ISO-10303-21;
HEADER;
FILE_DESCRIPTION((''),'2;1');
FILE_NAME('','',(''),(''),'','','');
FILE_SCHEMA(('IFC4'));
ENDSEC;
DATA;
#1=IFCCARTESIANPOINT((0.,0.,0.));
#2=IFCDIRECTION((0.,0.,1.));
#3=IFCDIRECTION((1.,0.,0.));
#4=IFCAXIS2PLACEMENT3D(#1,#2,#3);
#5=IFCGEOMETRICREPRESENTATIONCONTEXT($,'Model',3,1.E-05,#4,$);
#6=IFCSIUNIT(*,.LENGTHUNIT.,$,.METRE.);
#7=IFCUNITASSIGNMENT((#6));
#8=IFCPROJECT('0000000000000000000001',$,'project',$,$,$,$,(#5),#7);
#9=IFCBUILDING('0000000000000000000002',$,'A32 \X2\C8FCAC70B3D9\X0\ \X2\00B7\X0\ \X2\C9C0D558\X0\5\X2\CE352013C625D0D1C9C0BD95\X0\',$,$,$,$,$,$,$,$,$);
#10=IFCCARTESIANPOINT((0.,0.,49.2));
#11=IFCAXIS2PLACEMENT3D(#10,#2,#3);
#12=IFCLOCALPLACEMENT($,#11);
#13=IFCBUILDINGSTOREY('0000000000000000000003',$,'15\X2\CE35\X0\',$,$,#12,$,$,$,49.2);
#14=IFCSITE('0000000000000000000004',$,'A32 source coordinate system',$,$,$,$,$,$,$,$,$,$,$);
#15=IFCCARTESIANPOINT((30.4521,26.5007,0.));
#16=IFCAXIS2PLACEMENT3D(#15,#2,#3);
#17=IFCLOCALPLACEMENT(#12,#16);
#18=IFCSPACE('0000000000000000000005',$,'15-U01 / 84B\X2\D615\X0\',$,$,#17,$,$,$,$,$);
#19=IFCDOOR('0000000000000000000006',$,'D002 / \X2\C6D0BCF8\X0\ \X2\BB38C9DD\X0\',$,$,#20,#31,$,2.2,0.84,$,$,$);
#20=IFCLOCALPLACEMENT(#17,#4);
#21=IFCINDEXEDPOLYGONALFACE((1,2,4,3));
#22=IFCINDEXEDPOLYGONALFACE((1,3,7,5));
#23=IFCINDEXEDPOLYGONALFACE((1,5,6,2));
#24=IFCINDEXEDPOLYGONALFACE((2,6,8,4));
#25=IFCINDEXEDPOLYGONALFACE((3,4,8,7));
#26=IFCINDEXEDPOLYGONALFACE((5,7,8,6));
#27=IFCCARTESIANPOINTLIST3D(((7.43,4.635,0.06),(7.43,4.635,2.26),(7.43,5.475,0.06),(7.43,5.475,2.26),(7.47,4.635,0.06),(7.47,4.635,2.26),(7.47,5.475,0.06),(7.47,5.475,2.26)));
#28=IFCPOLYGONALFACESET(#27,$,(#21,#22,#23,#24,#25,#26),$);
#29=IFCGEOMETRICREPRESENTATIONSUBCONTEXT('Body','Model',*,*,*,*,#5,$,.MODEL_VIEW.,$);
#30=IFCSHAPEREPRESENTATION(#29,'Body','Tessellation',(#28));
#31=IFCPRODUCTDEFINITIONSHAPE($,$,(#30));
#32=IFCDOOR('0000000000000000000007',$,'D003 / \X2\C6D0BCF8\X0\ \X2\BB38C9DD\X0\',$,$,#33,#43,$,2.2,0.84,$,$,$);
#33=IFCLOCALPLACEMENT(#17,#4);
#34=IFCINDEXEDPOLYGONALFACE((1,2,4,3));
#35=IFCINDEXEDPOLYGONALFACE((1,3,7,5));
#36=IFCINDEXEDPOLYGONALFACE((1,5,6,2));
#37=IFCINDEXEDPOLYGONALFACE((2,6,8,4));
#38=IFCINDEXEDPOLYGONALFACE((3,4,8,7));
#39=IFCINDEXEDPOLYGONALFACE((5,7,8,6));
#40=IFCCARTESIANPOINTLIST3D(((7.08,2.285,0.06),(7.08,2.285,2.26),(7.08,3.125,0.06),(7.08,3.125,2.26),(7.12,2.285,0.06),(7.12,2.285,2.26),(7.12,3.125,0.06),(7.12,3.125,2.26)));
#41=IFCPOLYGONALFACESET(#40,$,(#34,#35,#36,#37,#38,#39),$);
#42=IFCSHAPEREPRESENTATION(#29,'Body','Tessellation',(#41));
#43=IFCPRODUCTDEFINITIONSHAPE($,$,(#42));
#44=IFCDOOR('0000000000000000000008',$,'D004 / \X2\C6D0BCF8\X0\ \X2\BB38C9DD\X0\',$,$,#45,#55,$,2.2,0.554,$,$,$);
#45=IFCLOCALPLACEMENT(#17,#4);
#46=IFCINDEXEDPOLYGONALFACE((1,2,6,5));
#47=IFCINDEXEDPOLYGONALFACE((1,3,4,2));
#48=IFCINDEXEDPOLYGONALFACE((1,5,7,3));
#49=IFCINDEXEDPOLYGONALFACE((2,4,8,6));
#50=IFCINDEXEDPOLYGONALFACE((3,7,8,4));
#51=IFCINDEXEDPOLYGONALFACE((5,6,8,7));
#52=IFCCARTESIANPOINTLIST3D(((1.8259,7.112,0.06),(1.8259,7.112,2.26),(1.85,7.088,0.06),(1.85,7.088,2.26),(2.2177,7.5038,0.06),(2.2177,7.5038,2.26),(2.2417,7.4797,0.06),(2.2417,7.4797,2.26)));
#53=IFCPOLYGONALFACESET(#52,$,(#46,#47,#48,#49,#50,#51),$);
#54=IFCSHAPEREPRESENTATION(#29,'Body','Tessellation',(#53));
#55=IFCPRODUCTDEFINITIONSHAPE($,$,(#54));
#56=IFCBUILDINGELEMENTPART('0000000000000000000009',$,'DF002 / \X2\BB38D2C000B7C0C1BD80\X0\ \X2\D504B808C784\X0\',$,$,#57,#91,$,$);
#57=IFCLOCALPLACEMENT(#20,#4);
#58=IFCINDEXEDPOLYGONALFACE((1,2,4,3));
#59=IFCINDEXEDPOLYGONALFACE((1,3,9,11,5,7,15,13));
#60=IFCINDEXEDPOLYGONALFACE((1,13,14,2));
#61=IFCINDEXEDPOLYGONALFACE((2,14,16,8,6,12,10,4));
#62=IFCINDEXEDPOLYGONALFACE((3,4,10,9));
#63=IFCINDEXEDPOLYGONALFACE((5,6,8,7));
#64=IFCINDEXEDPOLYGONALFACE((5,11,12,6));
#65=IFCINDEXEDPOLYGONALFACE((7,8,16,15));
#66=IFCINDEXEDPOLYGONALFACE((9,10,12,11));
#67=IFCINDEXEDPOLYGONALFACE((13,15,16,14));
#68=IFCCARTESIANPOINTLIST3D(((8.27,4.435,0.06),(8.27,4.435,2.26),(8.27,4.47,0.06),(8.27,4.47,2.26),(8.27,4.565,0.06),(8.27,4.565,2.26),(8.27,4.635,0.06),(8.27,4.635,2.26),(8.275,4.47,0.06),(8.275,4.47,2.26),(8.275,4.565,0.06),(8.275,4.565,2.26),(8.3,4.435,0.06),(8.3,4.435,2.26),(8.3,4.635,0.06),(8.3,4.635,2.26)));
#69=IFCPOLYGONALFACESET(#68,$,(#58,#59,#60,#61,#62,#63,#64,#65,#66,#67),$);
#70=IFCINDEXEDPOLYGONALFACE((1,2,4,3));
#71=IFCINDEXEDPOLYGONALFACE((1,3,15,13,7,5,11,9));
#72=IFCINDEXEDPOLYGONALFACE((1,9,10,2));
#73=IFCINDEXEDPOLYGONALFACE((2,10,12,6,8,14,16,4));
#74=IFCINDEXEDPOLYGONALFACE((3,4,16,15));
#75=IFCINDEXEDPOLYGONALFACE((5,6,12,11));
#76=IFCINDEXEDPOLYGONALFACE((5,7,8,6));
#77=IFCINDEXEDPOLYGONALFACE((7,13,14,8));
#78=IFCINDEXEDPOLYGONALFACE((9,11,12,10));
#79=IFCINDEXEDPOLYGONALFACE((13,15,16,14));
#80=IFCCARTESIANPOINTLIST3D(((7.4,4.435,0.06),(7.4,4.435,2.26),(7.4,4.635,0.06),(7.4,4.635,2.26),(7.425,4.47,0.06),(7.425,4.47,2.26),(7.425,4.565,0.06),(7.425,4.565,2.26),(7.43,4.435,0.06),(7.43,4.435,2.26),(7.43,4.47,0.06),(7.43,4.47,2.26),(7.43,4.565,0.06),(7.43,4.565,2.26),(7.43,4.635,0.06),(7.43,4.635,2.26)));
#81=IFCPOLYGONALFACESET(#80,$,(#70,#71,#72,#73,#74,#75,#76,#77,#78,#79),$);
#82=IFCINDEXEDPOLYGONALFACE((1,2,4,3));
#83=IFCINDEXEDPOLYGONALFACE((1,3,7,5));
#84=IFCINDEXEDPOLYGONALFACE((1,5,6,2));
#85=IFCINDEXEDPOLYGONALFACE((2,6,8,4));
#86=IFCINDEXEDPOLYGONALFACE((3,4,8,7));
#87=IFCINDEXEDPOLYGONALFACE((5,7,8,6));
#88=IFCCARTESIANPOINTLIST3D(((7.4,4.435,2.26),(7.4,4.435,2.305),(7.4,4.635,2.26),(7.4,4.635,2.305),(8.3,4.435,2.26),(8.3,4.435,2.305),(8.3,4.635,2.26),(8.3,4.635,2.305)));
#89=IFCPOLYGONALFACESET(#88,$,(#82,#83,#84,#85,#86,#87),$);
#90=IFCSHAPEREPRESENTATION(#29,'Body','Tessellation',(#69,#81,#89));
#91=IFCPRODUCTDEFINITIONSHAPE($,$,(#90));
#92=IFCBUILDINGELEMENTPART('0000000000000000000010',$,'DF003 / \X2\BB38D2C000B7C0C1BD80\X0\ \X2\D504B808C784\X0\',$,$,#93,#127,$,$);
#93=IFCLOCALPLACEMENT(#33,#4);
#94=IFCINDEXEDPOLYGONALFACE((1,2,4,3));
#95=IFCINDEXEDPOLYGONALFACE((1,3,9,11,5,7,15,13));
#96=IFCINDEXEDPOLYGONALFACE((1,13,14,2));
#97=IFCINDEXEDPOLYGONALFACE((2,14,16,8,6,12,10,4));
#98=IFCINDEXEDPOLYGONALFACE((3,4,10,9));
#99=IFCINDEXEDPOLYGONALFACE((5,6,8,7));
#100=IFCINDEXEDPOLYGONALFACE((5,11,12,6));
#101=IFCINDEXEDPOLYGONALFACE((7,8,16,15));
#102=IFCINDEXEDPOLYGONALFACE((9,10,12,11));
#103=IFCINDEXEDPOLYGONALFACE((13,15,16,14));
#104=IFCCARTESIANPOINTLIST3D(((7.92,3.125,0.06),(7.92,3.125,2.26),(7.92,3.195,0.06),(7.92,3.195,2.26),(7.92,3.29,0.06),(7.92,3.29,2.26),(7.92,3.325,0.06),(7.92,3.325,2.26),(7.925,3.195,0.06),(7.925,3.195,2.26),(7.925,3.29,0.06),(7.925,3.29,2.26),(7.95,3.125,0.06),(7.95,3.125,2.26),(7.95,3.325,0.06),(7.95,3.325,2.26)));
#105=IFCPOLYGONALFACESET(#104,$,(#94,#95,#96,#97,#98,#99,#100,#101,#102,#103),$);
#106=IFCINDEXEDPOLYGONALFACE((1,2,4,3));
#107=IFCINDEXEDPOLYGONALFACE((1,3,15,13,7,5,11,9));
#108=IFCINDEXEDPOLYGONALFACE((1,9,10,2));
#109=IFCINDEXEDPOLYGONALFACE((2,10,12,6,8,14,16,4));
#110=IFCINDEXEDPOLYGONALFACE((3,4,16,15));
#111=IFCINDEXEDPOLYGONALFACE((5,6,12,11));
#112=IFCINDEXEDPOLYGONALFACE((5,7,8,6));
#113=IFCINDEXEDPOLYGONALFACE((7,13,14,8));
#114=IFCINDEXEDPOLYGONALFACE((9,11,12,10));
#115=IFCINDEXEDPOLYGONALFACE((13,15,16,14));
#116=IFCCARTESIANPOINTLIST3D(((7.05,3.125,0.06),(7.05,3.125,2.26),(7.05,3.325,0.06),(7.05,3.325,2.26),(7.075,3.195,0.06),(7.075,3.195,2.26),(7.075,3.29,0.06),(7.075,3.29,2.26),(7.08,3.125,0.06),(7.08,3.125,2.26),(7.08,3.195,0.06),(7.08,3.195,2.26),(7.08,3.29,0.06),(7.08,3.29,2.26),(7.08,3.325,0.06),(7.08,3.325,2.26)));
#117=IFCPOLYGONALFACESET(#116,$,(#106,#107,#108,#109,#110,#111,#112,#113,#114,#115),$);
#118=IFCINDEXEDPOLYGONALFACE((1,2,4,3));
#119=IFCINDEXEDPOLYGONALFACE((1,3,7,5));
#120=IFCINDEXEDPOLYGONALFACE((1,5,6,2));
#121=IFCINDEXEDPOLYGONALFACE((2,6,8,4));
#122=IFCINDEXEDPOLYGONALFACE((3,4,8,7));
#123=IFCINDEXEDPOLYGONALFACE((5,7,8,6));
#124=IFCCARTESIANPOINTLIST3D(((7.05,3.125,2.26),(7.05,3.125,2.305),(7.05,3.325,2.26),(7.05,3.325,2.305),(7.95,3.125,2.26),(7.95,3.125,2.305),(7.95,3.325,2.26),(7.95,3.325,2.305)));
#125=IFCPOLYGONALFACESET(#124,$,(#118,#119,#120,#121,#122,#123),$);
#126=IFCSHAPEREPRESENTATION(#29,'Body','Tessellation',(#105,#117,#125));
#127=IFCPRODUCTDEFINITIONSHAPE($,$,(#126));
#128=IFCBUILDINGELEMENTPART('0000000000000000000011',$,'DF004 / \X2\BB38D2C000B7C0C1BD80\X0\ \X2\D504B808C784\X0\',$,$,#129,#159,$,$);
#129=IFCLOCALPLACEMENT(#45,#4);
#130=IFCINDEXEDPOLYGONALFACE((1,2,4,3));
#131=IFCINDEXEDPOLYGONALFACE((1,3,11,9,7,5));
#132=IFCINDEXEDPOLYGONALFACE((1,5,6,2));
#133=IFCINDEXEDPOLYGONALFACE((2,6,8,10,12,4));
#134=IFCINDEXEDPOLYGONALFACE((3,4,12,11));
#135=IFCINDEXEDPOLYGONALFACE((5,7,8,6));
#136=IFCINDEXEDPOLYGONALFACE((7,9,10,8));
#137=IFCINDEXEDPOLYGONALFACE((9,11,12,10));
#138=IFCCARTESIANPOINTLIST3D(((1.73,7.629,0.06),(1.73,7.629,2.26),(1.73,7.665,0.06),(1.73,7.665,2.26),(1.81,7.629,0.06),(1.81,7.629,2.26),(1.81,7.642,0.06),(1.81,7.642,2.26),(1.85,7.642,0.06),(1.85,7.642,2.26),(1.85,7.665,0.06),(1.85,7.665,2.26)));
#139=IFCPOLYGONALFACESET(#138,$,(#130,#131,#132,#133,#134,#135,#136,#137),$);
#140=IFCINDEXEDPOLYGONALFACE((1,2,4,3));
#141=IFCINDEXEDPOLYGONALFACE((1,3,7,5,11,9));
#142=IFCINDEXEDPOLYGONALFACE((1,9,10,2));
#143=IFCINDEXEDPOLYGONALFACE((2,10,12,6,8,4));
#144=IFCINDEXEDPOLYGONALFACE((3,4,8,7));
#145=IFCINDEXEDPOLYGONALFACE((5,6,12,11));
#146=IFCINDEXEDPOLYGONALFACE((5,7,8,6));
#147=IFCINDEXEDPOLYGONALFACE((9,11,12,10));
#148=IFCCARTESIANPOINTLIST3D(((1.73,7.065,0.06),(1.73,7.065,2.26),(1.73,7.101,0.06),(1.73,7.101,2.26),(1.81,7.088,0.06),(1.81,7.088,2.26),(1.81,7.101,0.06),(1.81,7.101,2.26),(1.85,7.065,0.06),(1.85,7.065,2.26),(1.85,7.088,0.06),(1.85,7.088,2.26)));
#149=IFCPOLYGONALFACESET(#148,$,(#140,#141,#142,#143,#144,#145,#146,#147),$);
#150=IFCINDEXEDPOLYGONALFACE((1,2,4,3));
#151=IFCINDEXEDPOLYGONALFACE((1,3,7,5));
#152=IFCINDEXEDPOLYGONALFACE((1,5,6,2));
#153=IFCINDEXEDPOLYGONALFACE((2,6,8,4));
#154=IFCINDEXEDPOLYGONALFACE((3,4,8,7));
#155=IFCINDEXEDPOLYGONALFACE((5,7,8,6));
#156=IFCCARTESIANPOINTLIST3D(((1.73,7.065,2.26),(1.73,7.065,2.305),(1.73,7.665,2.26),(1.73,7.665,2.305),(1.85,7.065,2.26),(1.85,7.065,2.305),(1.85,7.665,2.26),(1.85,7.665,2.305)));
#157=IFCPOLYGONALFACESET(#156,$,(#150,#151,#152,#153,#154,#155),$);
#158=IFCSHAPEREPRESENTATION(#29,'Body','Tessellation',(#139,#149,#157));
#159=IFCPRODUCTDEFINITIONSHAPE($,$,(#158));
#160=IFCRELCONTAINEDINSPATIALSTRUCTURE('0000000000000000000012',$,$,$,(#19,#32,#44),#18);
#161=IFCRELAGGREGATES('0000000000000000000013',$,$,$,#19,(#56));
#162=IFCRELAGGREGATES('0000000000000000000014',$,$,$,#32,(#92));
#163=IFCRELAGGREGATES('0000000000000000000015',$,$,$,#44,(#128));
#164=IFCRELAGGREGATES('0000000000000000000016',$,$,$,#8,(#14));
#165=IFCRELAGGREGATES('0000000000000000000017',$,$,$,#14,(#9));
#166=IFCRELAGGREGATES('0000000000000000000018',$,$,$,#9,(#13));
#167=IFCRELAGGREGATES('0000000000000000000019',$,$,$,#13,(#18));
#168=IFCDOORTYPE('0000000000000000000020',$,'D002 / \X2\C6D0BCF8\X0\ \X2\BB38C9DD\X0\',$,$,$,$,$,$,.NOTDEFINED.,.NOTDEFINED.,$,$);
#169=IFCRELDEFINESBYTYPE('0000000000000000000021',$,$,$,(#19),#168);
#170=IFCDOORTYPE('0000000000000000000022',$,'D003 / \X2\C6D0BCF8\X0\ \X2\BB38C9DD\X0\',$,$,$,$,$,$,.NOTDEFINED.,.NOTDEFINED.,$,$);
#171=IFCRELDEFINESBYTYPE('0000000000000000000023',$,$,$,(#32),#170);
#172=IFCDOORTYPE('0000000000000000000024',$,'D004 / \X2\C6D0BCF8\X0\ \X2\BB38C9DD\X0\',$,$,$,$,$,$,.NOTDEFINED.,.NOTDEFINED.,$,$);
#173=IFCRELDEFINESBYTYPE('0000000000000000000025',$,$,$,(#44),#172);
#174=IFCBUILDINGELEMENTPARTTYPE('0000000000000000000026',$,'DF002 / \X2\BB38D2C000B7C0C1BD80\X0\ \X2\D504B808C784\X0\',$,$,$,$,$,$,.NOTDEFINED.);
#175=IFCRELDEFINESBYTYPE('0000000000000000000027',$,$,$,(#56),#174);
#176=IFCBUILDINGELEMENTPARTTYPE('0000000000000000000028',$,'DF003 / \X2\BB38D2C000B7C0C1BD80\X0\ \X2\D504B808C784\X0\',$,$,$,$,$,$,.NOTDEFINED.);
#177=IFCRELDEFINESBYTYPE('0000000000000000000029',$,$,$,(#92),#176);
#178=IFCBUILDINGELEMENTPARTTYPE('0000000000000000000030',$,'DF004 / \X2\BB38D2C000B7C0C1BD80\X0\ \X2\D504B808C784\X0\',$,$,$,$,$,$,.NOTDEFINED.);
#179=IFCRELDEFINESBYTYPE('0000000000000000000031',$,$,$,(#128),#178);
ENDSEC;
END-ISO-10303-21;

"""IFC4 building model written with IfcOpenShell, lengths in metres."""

from ifc_helpers import new_model, si_unit, frame, origin, origin_with_axes, place, context, subcontext, project, spatial, polyline, outline, extrude, source, transform, mapped, type_object, type_shapes, element, aggregate, save


model = new_model("IFC4")

# Units and contexts
model_context = context("Model", 3, precision=1e-05, world=origin_with_axes())
body_context = subcontext(model_context, "Body", "Model", "MODEL_VIEW")
ifc_project = project(units=[si_unit("LENGTHUNIT", "METRE")], contexts=[model_context])

# Site, building, storey, space
storey_placement = place(None, frame((0.0, 0.0, 49.2), z_axis=(0.0, 0.0, 1.0), x_axis=(1.0, 0.0, 0.0)))
space_placement = place(storey_placement, frame((30.4521, 26.5007, 0.0), z_axis=(0.0, 0.0, 1.0), x_axis=(1.0, 0.0, 0.0)))
site = spatial("IfcSite", under=ifc_project, Name="A32 source coordinate system")
building = spatial("IfcBuilding", under=site, Name="A32 주거동 · 지하5층–옥탑지붕")
storey = spatial("IfcBuildingStorey", under=building, at=storey_placement, Name="15층", Elevation=49.2)
space = spatial("IfcSpace", under=storey, at=space_placement, Name="15-U01 / 84B형")

# Doors
door_type_1 = type_object("IfcDoorType", Name="D002 / 원본 문짝", OperationType="NOTDEFINED", PredefinedType="NOTDEFINED")
shared_shape_1 = source(origin(), body_context, "Body", "SweptSolid", [
    extrude(outline(polyline([(7.43, 4.635), (7.43, 5.475), (7.47, 5.475), (7.47, 4.635), (7.43, 4.635)])), frame((0.0, 0.0, 0.06)), (0.0, 0.0, 1.0), 2.2),
])
type_shapes(door_type_1, [shared_shape_1])
door_1_placement = place(space_placement, origin_with_axes())
door_1 = element("IfcDoor", 1, at=door_1_placement, inside=space, type_object=door_type_1, Name="D002 / 원본 문짝", OverallHeight=2.2, OverallWidth=0.84, context=body_context, shape_type="MappedRepresentation", body=[
    mapped(shared_shape_1, transform((0.0, 0.0, 0.0), scale=1.0)),
])
door_type_2 = type_object("IfcDoorType", Name="D003 / 원본 문짝", OperationType="NOTDEFINED", PredefinedType="NOTDEFINED")
shared_shape_2 = source(origin(), body_context, "Body", "SweptSolid", [
    extrude(outline(polyline([(7.12, 2.285), (7.08, 2.285), (7.08, 3.125), (7.12, 3.125), (7.12, 2.285)])), frame((0.0, 0.0, 0.06)), (0.0, 0.0, 1.0), 2.2),
])
type_shapes(door_type_2, [shared_shape_2])
door_2_placement = place(space_placement, origin_with_axes())
door_2 = element("IfcDoor", 2, at=door_2_placement, inside=space, type_object=door_type_2, Name="D003 / 원본 문짝", OverallHeight=2.2, OverallWidth=0.84, context=body_context, shape_type="MappedRepresentation", body=[
    mapped(shared_shape_2, transform((0.0, 0.0, 0.0), scale=1.0)),
])
door_type_3 = type_object("IfcDoorType", Name="D004 / 원본 문짝", OperationType="NOTDEFINED", PredefinedType="NOTDEFINED")
shared_shape_3 = source(origin(), body_context, "Body", "SweptSolid", [
    extrude(outline(polyline([(2.2177, 7.5038), (2.2417, 7.4797), (1.85, 7.088), (1.8259, 7.112), (2.2177, 7.5038)])), frame((0.0, 0.0, 0.06)), (0.0, 0.0, 1.0), 2.2),
])
type_shapes(door_type_3, [shared_shape_3])
door_3_placement = place(space_placement, origin_with_axes())
door_3 = element("IfcDoor", 3, at=door_3_placement, inside=space, type_object=door_type_3, Name="D004 / 원본 문짝", OverallHeight=2.2, OverallWidth=0.554, context=body_context, shape_type="MappedRepresentation", body=[
    mapped(shared_shape_3, transform((0.0, 0.0, 0.0), scale=1.0)),
])

# Building element parts
building_element_part_type_1 = type_object("IfcBuildingElementPartType", Name="DF002 / 문틀·상부 프레임", PredefinedType="NOTDEFINED")
shared_shape_4 = source(origin(), body_context, "Body", "SweptSolid", [
    extrude(outline(polyline([(8.3, 4.435), (8.27, 4.435), (8.27, 4.47), (8.275, 4.47), (8.275, 4.565), (8.27, 4.565), (8.27, 4.635), (8.3, 4.635), (8.3, 4.435)])), frame((0.0, 0.0, 0.06)), (0.0, 0.0, 1.0), 2.2),
    extrude(outline(polyline([(7.43, 4.635), (7.43, 4.565), (7.425, 4.565), (7.425, 4.47), (7.43, 4.47), (7.43, 4.435), (7.4, 4.435), (7.4, 4.635), (7.43, 4.635)])), frame((0.0, 0.0, 0.06)), (0.0, 0.0, 1.0), 2.2),
    extrude(outline(polyline([(7.4, 4.435), (7.4, 4.635), (8.3, 4.635), (8.3, 4.435), (7.4, 4.435)])), frame((0.0, 0.0, 2.26)), (0.0, 0.0, 1.0), 0.045),
])
type_shapes(building_element_part_type_1, [shared_shape_4])
building_element_part_1_placement = place(door_1_placement, origin_with_axes())
building_element_part_1 = element("IfcBuildingElementPart", 4, at=building_element_part_1_placement, type_object=building_element_part_type_1, Name="DF002 / 문틀·상부 프레임", context=body_context, shape_type="MappedRepresentation", body=[
    mapped(shared_shape_4, transform((0.0, 0.0, 0.0), scale=1.0)),
])
aggregate(door_1, [building_element_part_1])
building_element_part_type_2 = type_object("IfcBuildingElementPartType", Name="DF003 / 문틀·상부 프레임", PredefinedType="NOTDEFINED")
shared_shape_5 = source(origin(), body_context, "Body", "SweptSolid", [
    extrude(outline(polyline([(7.92, 3.125), (7.92, 3.195), (7.925, 3.195), (7.925, 3.29), (7.92, 3.29), (7.92, 3.325), (7.95, 3.325), (7.95, 3.125), (7.92, 3.125)])), frame((0.0, 0.0, 0.06)), (0.0, 0.0, 1.0), 2.2),
    extrude(outline(polyline([(7.05, 3.325), (7.08, 3.325), (7.08, 3.29), (7.075, 3.29), (7.075, 3.195), (7.08, 3.195), (7.08, 3.125), (7.05, 3.125), (7.05, 3.325)])), frame((0.0, 0.0, 0.06)), (0.0, 0.0, 1.0), 2.2),
    extrude(outline(polyline([(7.05, 3.125), (7.05, 3.325), (7.95, 3.325), (7.95, 3.125), (7.05, 3.125)])), frame((0.0, 0.0, 2.26)), (0.0, 0.0, 1.0), 0.045),
])
type_shapes(building_element_part_type_2, [shared_shape_5])
building_element_part_2_placement = place(door_2_placement, origin_with_axes())
building_element_part_2 = element("IfcBuildingElementPart", 5, at=building_element_part_2_placement, type_object=building_element_part_type_2, Name="DF003 / 문틀·상부 프레임", context=body_context, shape_type="MappedRepresentation", body=[
    mapped(shared_shape_5, transform((0.0, 0.0, 0.0), scale=1.0)),
])
aggregate(door_2, [building_element_part_2])
building_element_part_type_3 = type_object("IfcBuildingElementPartType", Name="DF004 / 문틀·상부 프레임", PredefinedType="NOTDEFINED")
shared_shape_6 = source(origin(), body_context, "Body", "SweptSolid", [
    extrude(outline(polyline([(1.85, 7.665), (1.85, 7.642), (1.81, 7.642), (1.81, 7.629), (1.73, 7.629), (1.73, 7.665), (1.85, 7.665)])), frame((0.0, 0.0, 0.06)), (0.0, 0.0, 1.0), 2.2),
    extrude(outline(polyline([(1.73, 7.101), (1.81, 7.101), (1.81, 7.088), (1.85, 7.088), (1.85, 7.065), (1.73, 7.065), (1.73, 7.101)])), frame((0.0, 0.0, 0.06)), (0.0, 0.0, 1.0), 2.2),
    extrude(outline(polyline([(1.73, 7.065), (1.73, 7.665), (1.85, 7.665), (1.85, 7.065), (1.73, 7.065)])), frame((0.0, 0.0, 2.26)), (0.0, 0.0, 1.0), 0.045),
])
type_shapes(building_element_part_type_3, [shared_shape_6])
building_element_part_3_placement = place(door_3_placement, origin_with_axes())
building_element_part_3 = element("IfcBuildingElementPart", 6, at=building_element_part_3_placement, type_object=building_element_part_type_3, Name="DF004 / 문틀·상부 프레임", context=body_context, shape_type="MappedRepresentation", body=[
    mapped(shared_shape_6, transform((0.0, 0.0, 0.0), scale=1.0)),
])
aggregate(door_3, [building_element_part_3])

save(model, "model.ifc")
